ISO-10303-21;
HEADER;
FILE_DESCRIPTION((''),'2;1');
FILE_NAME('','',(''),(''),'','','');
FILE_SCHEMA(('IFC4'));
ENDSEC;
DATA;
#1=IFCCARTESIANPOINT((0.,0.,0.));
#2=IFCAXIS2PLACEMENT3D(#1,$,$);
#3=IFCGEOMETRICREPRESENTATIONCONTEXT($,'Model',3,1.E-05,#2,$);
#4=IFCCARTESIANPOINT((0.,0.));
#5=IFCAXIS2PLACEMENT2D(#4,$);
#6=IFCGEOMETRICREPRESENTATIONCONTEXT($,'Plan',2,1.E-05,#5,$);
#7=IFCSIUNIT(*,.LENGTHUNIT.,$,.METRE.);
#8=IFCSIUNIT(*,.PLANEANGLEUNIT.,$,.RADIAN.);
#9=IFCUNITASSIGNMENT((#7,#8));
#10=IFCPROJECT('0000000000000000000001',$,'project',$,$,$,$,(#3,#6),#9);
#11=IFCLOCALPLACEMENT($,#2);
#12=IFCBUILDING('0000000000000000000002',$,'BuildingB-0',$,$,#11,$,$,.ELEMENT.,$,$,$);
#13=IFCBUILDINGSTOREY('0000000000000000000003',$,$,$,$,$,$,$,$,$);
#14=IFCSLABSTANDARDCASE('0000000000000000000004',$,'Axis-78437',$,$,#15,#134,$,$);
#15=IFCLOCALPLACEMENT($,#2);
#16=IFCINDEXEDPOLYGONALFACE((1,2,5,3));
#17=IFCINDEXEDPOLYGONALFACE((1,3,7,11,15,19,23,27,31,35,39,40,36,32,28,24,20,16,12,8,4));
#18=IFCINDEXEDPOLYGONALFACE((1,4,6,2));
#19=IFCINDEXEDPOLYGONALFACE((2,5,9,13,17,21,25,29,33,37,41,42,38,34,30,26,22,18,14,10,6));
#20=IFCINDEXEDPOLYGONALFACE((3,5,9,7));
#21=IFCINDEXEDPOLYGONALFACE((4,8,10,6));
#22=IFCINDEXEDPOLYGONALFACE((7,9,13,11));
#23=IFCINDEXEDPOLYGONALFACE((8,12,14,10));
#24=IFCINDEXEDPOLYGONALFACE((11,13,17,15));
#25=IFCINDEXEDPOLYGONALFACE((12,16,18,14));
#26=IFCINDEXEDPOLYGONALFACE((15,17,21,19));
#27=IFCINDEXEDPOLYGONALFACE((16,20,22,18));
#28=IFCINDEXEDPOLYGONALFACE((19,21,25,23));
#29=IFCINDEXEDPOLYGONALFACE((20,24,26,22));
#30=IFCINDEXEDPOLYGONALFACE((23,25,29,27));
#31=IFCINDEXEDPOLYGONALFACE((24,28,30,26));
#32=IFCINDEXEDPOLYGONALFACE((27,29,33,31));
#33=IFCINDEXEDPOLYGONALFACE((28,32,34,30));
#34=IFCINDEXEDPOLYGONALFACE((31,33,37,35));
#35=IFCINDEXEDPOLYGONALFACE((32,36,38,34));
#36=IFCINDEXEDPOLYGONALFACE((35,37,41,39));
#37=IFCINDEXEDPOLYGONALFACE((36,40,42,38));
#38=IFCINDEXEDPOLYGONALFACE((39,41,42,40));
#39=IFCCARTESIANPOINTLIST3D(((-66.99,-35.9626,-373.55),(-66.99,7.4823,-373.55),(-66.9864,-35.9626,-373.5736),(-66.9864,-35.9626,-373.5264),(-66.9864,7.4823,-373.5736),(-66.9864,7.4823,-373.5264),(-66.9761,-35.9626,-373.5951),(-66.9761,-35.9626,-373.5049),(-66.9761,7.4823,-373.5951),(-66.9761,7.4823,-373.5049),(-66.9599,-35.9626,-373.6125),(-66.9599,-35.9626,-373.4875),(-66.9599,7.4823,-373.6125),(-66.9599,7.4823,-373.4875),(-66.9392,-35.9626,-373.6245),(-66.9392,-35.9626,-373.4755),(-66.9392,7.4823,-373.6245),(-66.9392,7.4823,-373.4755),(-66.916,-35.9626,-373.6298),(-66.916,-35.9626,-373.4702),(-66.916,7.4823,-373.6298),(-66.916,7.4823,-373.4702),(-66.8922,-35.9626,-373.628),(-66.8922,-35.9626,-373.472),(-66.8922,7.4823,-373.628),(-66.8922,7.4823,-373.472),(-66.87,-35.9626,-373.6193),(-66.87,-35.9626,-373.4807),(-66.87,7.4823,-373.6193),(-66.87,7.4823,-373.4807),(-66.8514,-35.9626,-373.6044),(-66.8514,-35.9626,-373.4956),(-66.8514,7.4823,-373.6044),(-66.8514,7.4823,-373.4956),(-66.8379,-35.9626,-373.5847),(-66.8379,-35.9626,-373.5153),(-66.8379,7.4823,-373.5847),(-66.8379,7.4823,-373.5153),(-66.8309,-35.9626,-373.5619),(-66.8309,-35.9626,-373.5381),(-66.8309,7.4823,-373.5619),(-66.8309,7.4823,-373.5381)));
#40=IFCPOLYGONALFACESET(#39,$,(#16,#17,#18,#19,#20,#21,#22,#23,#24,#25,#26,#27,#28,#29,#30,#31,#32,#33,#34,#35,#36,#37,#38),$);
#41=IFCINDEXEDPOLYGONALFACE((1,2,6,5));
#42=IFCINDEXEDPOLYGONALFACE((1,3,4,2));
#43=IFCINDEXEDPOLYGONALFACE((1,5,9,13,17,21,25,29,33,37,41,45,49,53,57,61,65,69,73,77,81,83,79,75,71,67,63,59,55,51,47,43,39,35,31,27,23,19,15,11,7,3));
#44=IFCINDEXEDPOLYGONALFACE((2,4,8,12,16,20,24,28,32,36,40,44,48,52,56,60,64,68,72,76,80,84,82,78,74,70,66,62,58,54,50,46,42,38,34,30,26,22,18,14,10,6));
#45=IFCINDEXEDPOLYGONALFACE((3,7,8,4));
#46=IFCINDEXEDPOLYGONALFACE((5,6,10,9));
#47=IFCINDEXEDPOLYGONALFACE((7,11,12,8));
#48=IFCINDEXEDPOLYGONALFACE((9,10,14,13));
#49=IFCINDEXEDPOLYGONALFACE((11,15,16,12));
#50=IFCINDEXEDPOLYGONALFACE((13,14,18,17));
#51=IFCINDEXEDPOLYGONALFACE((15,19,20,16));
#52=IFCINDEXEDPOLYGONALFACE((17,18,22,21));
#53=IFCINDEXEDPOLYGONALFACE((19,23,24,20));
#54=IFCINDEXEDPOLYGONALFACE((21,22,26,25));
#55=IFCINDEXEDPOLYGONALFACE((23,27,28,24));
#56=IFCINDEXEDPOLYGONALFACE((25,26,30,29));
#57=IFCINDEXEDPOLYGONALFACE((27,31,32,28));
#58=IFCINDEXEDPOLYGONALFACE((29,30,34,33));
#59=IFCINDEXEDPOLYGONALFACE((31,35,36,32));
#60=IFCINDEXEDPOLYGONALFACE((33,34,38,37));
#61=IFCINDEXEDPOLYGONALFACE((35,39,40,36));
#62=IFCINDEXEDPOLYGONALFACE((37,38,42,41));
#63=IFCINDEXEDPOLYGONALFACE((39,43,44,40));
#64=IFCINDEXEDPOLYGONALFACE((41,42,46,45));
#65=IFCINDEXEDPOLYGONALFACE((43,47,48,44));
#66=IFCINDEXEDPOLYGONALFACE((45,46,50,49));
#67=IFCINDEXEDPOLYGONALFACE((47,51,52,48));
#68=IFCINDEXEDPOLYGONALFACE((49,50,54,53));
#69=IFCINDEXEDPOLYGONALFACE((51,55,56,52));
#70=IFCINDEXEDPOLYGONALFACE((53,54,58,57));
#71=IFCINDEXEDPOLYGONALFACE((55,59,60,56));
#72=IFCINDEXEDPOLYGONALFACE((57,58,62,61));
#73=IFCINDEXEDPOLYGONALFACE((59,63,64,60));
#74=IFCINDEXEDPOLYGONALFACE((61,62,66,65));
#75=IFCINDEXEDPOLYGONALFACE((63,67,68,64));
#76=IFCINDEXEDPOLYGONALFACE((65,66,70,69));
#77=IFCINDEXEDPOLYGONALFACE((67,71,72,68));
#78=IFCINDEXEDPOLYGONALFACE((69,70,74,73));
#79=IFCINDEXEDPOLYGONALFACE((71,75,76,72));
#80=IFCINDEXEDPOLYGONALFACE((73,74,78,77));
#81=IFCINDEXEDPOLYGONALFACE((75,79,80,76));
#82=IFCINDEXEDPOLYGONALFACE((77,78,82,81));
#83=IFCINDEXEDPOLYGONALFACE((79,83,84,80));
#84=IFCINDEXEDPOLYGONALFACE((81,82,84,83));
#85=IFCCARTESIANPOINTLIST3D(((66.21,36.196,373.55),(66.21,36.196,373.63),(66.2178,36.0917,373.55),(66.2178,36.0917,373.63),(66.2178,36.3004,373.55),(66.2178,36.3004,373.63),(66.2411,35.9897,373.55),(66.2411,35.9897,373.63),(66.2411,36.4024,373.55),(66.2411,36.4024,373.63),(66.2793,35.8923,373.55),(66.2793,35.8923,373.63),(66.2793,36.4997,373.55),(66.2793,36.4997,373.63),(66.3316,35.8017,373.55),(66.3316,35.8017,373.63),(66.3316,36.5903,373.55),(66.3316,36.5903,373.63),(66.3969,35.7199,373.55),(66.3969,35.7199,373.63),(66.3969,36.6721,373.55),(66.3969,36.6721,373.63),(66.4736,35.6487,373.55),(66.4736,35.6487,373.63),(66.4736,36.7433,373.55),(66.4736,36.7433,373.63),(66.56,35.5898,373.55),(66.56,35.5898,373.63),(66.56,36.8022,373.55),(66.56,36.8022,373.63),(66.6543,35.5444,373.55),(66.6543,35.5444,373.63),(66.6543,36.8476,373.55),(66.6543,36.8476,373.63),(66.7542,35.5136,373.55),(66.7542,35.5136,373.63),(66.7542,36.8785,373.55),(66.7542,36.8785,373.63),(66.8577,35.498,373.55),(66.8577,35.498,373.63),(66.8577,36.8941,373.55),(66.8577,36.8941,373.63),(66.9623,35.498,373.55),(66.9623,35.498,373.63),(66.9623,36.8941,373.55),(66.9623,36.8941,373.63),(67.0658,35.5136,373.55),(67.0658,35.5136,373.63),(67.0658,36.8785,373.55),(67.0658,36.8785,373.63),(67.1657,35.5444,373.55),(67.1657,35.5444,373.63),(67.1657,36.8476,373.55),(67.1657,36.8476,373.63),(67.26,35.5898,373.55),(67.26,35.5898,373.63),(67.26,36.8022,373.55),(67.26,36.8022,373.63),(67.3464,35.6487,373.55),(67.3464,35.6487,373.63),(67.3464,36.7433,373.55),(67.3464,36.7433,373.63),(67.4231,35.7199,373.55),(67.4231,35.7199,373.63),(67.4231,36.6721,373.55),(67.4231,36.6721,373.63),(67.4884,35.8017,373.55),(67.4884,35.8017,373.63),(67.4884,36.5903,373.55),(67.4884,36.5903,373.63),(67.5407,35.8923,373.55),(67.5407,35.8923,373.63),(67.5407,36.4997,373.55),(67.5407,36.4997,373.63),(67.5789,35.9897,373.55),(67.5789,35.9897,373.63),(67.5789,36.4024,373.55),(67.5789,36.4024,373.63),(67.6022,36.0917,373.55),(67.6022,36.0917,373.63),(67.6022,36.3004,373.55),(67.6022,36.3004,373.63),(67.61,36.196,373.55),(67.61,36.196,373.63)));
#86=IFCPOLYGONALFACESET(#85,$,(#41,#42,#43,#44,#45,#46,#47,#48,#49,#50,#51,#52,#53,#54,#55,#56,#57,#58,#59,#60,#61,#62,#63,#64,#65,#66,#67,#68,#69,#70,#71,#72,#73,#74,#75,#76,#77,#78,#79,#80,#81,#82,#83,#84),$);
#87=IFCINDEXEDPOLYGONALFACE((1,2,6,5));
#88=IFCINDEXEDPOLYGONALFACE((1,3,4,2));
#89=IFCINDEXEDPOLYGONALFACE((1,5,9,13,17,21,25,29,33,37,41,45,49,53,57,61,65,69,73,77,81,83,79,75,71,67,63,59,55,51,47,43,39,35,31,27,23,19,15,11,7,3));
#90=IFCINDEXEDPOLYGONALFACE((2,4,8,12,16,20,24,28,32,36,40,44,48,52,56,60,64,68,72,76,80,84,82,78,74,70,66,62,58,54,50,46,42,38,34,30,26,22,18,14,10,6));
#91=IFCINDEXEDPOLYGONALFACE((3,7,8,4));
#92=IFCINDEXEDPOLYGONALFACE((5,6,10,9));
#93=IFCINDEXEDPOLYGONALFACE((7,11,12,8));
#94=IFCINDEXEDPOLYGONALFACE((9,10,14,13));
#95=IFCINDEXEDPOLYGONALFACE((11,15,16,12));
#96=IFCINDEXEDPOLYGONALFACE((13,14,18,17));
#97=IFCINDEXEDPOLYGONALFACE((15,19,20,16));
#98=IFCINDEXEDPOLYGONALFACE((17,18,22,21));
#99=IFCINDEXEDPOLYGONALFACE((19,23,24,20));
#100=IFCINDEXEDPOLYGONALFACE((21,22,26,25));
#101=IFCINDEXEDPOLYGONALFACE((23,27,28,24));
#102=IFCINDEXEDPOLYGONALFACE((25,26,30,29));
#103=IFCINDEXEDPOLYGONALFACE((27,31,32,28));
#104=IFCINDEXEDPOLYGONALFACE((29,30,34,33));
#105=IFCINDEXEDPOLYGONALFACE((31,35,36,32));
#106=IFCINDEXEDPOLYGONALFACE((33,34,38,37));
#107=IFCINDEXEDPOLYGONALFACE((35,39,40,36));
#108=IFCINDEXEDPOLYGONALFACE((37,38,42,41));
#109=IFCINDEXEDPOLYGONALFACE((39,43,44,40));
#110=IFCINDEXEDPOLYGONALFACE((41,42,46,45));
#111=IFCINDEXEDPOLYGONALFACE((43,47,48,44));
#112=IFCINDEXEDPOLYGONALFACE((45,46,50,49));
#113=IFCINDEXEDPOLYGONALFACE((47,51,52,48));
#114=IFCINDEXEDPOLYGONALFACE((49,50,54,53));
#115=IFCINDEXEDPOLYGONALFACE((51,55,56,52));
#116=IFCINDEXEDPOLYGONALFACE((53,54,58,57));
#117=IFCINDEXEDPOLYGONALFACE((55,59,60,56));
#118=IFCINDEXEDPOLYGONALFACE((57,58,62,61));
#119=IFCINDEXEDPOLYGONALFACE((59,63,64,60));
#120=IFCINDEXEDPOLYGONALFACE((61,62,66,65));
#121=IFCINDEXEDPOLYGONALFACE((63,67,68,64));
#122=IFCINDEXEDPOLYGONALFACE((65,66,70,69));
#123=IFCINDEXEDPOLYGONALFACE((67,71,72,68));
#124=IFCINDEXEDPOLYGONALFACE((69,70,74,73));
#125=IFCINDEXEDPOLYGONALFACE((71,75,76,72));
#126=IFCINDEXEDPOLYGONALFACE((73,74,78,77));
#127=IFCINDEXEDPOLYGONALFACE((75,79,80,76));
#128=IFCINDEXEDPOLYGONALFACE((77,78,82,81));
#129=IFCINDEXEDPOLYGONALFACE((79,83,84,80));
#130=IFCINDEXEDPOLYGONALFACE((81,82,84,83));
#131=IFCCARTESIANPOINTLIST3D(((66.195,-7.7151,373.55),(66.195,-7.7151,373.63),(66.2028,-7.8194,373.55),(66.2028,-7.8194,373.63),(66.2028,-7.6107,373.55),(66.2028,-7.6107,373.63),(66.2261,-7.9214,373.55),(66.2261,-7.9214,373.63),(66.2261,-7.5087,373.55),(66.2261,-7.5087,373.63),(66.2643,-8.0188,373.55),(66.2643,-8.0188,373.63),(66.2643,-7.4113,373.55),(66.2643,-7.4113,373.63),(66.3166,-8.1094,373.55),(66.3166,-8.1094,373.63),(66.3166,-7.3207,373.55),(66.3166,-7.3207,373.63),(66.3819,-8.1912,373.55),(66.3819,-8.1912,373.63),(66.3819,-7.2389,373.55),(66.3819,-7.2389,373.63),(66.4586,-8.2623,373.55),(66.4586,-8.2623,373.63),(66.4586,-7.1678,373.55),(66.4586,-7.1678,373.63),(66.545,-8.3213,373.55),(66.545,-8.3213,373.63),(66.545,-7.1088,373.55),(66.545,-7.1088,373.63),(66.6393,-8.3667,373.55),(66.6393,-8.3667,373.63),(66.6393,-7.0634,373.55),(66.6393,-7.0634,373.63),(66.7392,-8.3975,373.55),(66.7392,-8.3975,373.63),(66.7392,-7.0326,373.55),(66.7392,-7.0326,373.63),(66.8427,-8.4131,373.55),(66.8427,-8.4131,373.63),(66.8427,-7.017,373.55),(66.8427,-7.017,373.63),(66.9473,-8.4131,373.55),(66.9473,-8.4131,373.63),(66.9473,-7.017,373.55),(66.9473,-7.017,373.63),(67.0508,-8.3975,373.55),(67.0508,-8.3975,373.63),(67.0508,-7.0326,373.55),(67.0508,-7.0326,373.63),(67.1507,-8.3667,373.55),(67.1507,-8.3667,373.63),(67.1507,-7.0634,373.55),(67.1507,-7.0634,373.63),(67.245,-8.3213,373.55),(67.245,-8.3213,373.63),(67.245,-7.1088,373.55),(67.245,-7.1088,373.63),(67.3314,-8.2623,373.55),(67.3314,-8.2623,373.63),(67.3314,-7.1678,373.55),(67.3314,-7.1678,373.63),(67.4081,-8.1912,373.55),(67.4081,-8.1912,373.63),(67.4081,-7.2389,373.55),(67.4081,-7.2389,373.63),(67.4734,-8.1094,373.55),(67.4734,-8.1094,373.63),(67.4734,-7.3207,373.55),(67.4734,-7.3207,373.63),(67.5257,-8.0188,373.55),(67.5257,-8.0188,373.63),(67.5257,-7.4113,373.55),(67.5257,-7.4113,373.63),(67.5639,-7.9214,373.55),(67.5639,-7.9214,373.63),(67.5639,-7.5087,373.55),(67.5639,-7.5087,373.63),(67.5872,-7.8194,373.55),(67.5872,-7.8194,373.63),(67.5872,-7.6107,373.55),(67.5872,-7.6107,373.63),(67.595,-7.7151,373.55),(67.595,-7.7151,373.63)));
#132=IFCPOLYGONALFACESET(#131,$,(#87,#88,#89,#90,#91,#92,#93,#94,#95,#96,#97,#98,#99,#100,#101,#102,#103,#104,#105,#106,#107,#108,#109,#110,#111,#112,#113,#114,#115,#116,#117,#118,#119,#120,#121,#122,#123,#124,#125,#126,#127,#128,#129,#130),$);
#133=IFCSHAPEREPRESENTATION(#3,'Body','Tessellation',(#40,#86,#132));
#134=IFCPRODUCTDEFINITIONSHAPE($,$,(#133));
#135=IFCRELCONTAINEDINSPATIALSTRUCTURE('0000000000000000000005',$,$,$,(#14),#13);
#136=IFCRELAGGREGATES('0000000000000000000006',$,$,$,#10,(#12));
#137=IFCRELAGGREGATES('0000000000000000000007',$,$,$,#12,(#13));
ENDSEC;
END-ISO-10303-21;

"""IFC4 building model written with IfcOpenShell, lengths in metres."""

from ifc_helpers import new_model, entity, si_unit, frame, origin, origin_2d, place, context, project, spatial, circle, extrude, element, save


model = new_model("IFC4")

# Units and contexts
model_context = context("Model", 3, precision=1e-05, world=origin())
plan_context = context("Plan", 2, precision=1e-05, world=origin_2d())
ifc_project = project(units=[si_unit("LENGTHUNIT", "METRE"), si_unit("PLANEANGLEUNIT", "RADIAN")], contexts=[model_context, plan_context])

# Building, storey
building_placement = place(None, origin())
building = spatial("IfcBuilding", under=ifc_project, at=building_placement, Name="BuildingB-0", CompositionType="ELEMENT")
storey = spatial("IfcBuildingStorey", under=building)

# Slab
element("IfcSlabStandardCase", 1, inside=storey, Name="Axis-78437", context=model_context, shape_type="AdvancedSweptSolid", body=[
    entity("IfcSurfaceCurveSweptAreaSolid", entity("IfcCircleProfileDef", "AREA", None, None, 0.08), None, entity("IfcPolyline", [entity("IfcCartesianPoint", [66.91, 35.9626, 373.55]), entity("IfcCartesianPoint", [66.91, -7.4823, 373.55])]), None, None, entity("IfcPlane", entity("IfcAxis2Placement3D", entity("IfcCartesianPoint", [66.91, 35.9626, 373.55]), entity("IfcDirection", [0.0, 0.0, 1.0]), entity("IfcDirection", [1.0, 0.0, 0.0])))),
    extrude(circle(Radius=0.7), frame((66.91, 36.196, 373.55)), (0.0, 0.0, 1.0), 0.08),
    extrude(circle(Radius=0.7), frame((66.895, -7.7151, 373.55)), (0.0, 0.0, 1.0), 0.08),
])

save(model, "model.ifc")
